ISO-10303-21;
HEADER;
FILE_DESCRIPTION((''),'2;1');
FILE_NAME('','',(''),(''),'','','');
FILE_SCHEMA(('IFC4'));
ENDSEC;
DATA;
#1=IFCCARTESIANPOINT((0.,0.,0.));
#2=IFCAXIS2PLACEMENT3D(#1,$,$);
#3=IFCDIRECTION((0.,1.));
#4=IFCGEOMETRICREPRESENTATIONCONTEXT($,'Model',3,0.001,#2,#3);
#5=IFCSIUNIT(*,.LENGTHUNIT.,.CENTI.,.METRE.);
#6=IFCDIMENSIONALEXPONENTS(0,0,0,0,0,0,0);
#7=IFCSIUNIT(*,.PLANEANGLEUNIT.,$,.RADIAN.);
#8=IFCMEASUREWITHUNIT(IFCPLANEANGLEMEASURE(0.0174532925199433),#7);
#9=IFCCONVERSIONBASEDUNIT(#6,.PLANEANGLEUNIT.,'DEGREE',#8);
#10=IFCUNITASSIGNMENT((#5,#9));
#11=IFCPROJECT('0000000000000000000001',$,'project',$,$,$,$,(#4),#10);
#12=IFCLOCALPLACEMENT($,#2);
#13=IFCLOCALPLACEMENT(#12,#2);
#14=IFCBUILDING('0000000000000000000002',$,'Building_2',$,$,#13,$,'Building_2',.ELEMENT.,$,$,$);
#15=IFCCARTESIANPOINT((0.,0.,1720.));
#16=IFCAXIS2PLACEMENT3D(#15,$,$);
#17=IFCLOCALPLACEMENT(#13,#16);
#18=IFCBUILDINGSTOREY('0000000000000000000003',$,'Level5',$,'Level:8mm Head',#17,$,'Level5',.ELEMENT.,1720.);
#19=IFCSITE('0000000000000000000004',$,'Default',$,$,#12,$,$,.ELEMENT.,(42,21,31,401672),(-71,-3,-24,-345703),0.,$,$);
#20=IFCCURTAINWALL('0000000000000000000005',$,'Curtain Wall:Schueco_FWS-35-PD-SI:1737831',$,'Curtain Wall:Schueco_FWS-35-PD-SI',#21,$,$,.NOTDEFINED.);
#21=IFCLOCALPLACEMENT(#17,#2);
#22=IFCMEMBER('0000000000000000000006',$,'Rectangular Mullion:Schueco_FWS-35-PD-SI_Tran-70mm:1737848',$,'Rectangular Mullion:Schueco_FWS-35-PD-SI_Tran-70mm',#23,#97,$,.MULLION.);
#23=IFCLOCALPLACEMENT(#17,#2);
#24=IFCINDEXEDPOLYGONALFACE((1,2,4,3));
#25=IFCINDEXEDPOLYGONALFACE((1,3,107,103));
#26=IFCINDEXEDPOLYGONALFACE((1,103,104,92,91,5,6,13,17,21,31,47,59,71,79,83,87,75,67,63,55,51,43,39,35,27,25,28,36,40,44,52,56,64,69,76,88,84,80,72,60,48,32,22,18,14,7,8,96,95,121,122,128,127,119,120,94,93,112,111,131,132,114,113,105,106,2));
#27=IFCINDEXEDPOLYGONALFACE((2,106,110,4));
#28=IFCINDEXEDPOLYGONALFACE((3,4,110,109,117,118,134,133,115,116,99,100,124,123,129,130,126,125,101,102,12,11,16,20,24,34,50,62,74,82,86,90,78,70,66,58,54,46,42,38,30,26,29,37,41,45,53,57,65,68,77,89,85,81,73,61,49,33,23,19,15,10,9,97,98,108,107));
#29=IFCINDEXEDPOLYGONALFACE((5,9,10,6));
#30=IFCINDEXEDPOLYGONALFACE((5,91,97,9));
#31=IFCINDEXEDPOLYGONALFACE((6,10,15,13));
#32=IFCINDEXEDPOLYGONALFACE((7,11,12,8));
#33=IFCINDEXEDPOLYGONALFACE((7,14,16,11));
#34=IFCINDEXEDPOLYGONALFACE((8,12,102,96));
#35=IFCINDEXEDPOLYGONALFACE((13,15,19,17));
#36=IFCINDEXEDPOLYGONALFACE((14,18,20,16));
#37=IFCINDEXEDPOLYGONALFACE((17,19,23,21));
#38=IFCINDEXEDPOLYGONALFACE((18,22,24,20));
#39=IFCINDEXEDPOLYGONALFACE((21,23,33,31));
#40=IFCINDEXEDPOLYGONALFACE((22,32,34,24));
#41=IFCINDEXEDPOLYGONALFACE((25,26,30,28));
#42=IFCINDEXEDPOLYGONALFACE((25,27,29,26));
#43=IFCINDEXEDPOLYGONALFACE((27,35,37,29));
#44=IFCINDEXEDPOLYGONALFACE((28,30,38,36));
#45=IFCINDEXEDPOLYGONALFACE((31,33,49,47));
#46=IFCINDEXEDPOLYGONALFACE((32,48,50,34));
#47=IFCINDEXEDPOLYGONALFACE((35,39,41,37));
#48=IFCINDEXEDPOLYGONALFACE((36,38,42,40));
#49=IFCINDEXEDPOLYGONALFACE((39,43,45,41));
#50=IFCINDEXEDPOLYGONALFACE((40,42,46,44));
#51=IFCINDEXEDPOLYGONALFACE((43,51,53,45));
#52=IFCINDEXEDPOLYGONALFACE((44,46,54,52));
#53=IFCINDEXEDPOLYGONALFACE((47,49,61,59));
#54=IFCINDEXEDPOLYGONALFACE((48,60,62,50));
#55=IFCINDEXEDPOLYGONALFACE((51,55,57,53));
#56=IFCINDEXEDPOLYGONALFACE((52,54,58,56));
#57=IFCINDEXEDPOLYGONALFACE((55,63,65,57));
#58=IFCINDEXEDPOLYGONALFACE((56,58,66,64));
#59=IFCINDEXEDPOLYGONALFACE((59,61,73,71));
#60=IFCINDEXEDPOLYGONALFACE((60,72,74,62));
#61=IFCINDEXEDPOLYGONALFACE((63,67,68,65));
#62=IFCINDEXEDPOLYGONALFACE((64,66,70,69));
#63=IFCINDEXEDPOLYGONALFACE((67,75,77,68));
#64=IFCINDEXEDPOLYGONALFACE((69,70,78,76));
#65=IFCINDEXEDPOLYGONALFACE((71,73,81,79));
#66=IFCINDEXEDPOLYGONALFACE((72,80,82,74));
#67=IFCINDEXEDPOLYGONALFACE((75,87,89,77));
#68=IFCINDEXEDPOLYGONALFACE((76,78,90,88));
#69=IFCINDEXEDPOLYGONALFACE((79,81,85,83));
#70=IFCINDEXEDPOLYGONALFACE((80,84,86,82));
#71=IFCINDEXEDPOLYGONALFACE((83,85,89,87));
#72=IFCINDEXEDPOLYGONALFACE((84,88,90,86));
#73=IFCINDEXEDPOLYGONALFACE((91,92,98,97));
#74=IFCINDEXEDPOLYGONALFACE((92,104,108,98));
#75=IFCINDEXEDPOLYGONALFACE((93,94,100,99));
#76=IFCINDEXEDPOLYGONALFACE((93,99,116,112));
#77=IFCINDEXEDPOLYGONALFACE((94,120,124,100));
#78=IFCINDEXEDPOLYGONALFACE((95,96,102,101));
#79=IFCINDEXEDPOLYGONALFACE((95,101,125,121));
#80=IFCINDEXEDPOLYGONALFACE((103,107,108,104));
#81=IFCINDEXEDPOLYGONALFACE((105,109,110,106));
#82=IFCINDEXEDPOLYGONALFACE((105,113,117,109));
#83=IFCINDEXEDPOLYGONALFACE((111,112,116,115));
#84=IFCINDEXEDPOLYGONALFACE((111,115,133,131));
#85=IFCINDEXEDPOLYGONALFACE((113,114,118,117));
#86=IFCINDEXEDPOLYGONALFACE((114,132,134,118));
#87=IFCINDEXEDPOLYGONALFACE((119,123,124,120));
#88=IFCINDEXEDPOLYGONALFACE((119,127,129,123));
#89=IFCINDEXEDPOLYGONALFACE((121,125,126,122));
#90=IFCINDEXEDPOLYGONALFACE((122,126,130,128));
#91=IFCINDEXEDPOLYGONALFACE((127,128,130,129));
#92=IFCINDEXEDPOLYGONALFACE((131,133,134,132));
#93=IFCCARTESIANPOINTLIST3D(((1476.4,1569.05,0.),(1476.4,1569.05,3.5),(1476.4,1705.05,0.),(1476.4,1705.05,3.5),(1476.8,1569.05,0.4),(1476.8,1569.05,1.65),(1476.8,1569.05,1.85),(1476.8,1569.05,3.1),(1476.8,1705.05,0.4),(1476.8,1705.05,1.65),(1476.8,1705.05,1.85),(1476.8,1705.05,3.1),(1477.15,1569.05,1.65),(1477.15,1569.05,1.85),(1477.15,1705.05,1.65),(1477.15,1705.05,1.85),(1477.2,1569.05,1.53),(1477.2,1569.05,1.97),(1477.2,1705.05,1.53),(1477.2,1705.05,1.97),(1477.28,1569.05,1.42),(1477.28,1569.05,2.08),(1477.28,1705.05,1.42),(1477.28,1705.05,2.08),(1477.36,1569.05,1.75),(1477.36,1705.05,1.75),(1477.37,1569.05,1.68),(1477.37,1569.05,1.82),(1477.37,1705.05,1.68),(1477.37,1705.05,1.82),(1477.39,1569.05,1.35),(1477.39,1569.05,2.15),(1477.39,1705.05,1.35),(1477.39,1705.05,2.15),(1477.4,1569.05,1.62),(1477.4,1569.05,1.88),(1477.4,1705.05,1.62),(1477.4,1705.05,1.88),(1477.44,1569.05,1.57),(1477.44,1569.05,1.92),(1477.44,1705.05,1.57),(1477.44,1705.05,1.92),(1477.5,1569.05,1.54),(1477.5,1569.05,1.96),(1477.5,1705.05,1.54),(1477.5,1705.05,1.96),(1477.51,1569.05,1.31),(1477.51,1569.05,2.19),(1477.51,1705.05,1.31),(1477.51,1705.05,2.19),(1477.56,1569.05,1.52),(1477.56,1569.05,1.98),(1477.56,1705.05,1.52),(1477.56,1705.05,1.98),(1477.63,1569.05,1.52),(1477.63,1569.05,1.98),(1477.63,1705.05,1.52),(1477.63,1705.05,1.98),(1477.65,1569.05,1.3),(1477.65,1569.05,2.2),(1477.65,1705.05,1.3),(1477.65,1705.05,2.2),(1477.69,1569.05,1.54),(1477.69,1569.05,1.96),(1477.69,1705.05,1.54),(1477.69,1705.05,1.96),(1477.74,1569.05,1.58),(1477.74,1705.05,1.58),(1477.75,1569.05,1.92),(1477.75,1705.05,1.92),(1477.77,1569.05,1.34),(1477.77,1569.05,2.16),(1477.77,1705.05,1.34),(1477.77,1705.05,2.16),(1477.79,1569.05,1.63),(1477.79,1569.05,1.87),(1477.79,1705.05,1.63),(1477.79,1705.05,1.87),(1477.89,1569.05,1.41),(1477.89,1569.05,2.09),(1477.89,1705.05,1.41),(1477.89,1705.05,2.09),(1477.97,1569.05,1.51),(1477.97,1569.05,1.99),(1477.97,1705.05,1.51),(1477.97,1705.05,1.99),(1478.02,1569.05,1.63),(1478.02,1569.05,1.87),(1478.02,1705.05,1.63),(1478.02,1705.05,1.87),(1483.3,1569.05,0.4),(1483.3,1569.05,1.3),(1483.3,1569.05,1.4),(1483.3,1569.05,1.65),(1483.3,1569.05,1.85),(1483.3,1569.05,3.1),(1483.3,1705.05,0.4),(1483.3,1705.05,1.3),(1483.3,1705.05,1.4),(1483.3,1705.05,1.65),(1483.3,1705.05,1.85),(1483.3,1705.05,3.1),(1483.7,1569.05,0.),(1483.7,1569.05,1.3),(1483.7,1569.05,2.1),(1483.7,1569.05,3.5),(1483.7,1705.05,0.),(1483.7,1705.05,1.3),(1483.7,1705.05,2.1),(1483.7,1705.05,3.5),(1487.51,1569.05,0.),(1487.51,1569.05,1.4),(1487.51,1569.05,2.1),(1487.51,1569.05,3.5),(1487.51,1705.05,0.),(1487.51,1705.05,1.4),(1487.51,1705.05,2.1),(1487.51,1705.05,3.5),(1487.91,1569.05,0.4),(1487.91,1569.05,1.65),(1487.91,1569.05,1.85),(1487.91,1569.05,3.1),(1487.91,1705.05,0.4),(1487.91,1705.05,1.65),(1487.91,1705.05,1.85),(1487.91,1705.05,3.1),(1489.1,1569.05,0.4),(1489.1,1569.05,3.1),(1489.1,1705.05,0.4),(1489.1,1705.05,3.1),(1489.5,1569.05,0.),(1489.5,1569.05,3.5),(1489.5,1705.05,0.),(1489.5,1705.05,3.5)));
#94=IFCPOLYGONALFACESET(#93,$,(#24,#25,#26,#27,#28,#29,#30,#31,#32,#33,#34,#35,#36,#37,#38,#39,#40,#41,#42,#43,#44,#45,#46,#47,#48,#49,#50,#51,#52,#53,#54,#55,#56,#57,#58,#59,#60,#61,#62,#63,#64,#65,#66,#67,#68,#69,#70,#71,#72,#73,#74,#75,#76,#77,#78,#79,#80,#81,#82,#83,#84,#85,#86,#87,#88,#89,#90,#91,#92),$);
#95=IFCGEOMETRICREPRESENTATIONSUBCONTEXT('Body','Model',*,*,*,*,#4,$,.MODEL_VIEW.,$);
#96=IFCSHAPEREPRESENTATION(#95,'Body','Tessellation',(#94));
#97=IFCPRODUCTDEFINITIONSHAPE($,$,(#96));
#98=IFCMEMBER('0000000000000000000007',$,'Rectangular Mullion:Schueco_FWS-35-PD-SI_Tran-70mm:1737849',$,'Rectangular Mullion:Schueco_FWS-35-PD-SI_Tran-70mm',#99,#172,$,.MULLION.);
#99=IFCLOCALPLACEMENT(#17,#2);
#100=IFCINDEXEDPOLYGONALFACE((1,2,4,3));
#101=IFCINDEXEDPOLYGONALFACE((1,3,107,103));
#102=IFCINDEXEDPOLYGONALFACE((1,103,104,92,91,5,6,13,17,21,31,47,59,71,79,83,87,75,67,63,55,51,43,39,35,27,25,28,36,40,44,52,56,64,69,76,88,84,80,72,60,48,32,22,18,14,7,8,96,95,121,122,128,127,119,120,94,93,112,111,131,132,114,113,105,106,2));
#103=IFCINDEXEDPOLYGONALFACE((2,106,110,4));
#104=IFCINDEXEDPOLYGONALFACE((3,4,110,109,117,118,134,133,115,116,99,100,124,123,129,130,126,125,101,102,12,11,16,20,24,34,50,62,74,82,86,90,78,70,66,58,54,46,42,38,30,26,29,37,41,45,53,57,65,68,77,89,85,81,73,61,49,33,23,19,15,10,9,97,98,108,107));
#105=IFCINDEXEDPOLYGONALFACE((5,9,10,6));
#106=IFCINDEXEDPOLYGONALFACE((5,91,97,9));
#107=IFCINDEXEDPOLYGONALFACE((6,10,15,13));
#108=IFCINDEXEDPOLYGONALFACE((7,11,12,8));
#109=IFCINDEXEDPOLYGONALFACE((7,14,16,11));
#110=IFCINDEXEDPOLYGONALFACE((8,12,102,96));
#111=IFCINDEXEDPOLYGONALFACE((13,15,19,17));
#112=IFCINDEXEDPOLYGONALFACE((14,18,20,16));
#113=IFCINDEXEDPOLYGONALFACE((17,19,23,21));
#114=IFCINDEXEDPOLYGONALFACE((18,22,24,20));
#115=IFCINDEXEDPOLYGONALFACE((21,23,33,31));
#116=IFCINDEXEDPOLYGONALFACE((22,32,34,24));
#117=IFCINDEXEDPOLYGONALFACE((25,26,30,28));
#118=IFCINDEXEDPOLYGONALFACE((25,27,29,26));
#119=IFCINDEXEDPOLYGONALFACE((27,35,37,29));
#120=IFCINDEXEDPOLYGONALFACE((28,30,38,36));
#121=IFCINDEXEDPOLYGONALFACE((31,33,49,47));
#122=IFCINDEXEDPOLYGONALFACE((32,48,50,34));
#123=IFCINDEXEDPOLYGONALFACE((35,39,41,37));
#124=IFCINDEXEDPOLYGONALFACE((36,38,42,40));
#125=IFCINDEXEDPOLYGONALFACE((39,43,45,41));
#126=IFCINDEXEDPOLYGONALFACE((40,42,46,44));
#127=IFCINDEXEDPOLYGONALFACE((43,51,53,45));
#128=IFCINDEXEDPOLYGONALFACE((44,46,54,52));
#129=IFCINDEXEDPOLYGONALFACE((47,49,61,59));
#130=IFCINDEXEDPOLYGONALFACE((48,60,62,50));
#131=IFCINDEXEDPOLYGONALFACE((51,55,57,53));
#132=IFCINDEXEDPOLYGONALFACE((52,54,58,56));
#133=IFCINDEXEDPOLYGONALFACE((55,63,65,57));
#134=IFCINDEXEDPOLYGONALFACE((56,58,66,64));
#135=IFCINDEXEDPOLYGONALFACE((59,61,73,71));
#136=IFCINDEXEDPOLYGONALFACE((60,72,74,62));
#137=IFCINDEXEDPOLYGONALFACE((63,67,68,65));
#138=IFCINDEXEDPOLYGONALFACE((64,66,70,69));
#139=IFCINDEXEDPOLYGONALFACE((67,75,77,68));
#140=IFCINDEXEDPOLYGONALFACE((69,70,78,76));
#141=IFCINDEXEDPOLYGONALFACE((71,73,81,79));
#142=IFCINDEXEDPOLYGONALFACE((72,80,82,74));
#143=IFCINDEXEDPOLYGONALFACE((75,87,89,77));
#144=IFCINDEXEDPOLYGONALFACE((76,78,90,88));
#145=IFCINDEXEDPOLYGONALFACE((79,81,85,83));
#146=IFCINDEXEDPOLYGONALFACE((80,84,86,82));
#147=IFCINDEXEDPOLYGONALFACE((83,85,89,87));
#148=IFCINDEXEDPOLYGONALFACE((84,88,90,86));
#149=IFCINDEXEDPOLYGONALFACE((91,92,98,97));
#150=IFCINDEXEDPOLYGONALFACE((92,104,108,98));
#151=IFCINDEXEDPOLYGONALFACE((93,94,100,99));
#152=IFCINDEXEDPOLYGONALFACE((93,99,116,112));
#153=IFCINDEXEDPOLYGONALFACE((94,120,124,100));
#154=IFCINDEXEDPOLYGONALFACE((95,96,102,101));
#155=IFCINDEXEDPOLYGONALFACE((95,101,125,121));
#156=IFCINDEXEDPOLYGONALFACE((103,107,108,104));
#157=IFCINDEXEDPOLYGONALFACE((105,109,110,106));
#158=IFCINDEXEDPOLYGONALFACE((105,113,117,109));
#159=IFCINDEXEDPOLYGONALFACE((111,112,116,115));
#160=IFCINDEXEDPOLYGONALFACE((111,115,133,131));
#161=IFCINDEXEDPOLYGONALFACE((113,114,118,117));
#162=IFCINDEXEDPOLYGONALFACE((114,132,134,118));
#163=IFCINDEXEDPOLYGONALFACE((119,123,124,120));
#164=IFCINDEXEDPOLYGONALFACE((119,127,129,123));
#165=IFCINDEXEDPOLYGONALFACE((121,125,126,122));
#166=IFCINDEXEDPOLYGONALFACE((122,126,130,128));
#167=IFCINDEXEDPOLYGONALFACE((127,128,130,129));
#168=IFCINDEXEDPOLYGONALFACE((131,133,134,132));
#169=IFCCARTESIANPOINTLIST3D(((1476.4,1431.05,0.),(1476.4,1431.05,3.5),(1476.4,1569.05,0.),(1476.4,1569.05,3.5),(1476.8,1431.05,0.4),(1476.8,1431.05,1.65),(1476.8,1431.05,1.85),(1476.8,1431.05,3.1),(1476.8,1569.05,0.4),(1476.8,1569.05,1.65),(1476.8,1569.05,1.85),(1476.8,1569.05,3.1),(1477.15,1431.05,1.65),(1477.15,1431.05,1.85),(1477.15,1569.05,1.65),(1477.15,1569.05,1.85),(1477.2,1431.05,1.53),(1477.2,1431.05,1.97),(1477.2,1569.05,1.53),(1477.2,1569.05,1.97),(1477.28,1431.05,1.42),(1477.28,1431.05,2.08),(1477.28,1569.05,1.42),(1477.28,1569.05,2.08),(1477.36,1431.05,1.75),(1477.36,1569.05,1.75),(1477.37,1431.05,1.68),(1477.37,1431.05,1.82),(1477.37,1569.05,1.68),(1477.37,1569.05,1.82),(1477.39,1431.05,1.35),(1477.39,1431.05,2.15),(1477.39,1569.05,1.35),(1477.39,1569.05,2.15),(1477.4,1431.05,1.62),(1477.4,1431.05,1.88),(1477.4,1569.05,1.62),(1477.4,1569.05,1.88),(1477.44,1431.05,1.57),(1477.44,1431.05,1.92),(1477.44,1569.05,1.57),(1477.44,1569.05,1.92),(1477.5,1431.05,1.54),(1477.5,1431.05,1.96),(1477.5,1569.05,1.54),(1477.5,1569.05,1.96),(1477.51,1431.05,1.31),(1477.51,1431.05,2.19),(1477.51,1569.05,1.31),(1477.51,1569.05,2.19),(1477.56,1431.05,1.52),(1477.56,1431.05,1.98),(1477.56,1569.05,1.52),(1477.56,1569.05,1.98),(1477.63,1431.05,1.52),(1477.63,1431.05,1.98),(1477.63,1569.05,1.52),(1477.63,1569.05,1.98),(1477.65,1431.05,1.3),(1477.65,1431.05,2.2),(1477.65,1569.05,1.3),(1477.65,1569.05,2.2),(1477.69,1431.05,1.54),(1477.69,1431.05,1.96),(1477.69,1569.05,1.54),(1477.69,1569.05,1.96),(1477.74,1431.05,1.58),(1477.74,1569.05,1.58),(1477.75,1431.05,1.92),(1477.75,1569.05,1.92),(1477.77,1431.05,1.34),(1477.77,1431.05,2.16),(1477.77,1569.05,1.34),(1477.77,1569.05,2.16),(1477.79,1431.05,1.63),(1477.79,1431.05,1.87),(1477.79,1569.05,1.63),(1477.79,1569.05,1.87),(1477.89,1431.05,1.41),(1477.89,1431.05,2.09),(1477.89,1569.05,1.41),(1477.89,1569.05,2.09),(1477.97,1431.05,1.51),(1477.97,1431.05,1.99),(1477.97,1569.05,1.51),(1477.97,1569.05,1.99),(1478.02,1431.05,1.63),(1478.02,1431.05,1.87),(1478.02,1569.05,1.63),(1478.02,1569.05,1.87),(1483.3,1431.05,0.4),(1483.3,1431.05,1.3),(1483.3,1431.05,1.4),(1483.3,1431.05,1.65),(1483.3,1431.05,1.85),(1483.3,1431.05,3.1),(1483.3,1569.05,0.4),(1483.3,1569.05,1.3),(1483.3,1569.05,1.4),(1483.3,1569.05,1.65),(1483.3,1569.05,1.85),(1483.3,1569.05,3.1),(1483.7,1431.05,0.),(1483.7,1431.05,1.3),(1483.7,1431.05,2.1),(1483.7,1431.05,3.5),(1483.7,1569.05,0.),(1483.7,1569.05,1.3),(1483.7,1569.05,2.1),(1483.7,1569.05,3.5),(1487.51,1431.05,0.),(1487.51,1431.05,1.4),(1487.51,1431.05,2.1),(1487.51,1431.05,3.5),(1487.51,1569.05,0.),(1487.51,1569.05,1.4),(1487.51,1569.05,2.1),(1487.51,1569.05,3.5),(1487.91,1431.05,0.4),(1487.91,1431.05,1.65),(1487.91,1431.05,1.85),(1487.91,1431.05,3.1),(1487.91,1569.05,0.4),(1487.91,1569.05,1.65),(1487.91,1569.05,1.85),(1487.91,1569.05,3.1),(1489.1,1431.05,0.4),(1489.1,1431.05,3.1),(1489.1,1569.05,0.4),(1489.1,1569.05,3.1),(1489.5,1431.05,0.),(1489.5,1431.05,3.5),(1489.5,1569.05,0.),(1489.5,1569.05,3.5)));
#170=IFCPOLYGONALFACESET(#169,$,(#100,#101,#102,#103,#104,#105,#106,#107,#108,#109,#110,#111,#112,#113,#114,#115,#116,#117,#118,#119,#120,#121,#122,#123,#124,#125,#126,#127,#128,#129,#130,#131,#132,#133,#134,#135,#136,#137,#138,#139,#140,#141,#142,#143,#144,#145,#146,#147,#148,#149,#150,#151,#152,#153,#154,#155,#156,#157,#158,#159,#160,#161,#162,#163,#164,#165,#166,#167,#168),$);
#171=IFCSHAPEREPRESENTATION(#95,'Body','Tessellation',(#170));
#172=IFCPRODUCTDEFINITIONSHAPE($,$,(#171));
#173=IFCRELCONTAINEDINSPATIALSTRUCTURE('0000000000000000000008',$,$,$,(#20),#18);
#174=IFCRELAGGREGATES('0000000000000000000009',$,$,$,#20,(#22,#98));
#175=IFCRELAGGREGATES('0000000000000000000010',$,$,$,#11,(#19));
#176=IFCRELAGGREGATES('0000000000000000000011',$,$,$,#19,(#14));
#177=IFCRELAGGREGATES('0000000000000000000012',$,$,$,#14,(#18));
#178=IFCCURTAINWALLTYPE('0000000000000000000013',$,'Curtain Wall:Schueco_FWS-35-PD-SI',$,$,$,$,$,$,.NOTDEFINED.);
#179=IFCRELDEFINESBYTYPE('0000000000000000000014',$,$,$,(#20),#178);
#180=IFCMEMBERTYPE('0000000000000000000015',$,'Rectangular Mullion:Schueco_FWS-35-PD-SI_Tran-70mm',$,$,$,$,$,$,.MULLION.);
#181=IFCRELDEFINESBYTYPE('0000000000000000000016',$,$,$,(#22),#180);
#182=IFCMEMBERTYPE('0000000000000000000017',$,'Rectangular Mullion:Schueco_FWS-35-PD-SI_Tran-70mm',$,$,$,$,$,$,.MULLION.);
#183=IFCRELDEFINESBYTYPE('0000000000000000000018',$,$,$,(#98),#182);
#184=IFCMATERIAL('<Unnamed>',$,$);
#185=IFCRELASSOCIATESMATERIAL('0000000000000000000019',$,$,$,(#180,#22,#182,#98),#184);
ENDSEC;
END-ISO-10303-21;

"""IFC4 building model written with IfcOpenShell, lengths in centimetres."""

from ifc_helpers import new_model, entity, si_unit, converted_unit, direction, frame, origin, place, context, subcontext, project, spatial, line, arc, indexed_curve, outline, extrude, source, transform, mapped, material, type_object, type_shapes, element, aggregate, save


model = new_model("IFC4")

# Units and contexts
model_context = context("Model", 3, precision=0.001, world=origin(), true_north=direction((0.0, 1.0)))
body_context = subcontext(model_context, "Body", "Model", "MODEL_VIEW")
ifc_project = project(units=[si_unit("LENGTHUNIT", "METRE", prefix="CENTI"), converted_unit("PLANEANGLEUNIT", "DEGREE", entity("IfcPlaneAngleMeasure", 0.0174532925199433), si_unit("PLANEANGLEUNIT", "RADIAN"), dimensions=[0, 0, 0, 0, 0, 0, 0])], contexts=[model_context])

# Site, building, storey
site_placement = place(None, origin())
site = spatial("IfcSite", under=ifc_project, at=site_placement, Name="Default", CompositionType="ELEMENT", RefLatitude=(42, 21, 31, 401672), RefLongitude=(-71, -3, -24, -345703), RefElevation=0.0)
building_placement = place(site_placement, origin())
building = spatial("IfcBuilding", under=site, at=building_placement, Name="Building_2", LongName="Building_2", CompositionType="ELEMENT")
storey_placement = place(building_placement, frame((0.0, 0.0, 1720.0)))
storey = spatial("IfcBuildingStorey", under=building, at=storey_placement, Name="Level5", ObjectType="Level:8mm Head", LongName="Level5", CompositionType="ELEMENT", Elevation=1720.0)

# Curtain wall, members
curtain_wall_type = type_object("IfcCurtainWallType", Name="Curtain Wall:Schueco_FWS-35-PD-SI", PredefinedType="NOTDEFINED")
curtain_wall_placement = place(storey_placement, frame((0.0, 0.0, -1720.0)))
curtain_wall = element("IfcCurtainWall", 1, at=curtain_wall_placement, inside=storey, type_object=curtain_wall_type, Name="Curtain Wall:Schueco_FWS-35-PD-SI:1737831", ObjectType="Curtain Wall:Schueco_FWS-35-PD-SI", PredefinedType="NOTDEFINED")
ifc_material_1 = material(Name="<Unnamed>")
member_type_1 = type_object("IfcMemberType", Name="Rectangular Mullion:Schueco_FWS-35-PD-SI_Tran-70mm", PredefinedType="MULLION", material=ifc_material_1)
shared_shape_1 = source(origin(), body_context, "Body", "SweptSolid", [
    extrude(outline(indexed_curve([(-6.52, -1.78), (0.78, -1.78), (0.78, -0.38), (4.59, -0.38), (4.59, -1.78), (6.58, -1.78), (6.58, 1.72), (4.59, 1.72), (4.59, 0.32), (0.38, 0.32), (0.38, 0.07), (4.99, 0.07), (4.99, 1.32), (6.18, 1.32), (6.18, -1.38), (4.99, -1.38), (4.99, -0.13), (0.38, -0.13), (0.38, -1.38), (-6.12, -1.38), (-6.12, -0.13), (-5.77, -0.13), (-5.34, -0.48), (-4.9, -0.15), (-5.14, -0.15), (-5.56, -0.03), (-5.14, 0.09), (-4.9, 0.09), (-5.34, 0.42), (-5.77, 0.07), (-6.12, 0.07), (-6.12, 1.32), (0.38, 1.32), (0.38, 0.42), (0.78, 0.42), (0.78, 1.72), (-6.52, 1.72)], segments=[line(1, 2, 3, 4, 5, 6, 7, 8, 9, 10, 11, 12, 13, 14, 15, 16, 17, 18, 19, 20, 21, 22), arc(22, 23, 24), line(24, 25), arc(25, 26, 27), line(27, 28), arc(28, 29, 30), line(30, 31, 32, 33, 34, 35, 36, 37, 1)], self_intersect=False)), frame((-1.72, 4.58, -136.0), z_axis=(0.0, 0.0, 1.0), x_axis=(0.0, -1.0, 0.0)), (0.0, 0.0, 1.0), 136.0),
])
type_shapes(member_type_1, [shared_shape_1])
member_1_placement = place(curtain_wall_placement, frame((1487.5, 1705.05, 1720.0), z_axis=(0.0, 1.0, 0.0), x_axis=(0.0, 0.0, -1.0)))
member_1 = element("IfcMember", 2, at=member_1_placement, type_object=member_type_1, material=ifc_material_1, Name="Rectangular Mullion:Schueco_FWS-35-PD-SI_Tran-70mm:1737848", ObjectType="Rectangular Mullion:Schueco_FWS-35-PD-SI_Tran-70mm", PredefinedType="MULLION", context=body_context, shape_type="MappedRepresentation", body=[
    mapped(shared_shape_1, transform((0.0, 0.0, 0.0), scale=1.0)),
])
member_type_2 = type_object("IfcMemberType", Name="Rectangular Mullion:Schueco_FWS-35-PD-SI_Tran-70mm", PredefinedType="MULLION", material=ifc_material_1)
shared_shape_2 = source(origin(), body_context, "Body", "SweptSolid", [
    extrude(outline(indexed_curve([(-6.52, -1.78), (0.78, -1.78), (0.78, -0.38), (4.59, -0.38), (4.59, -1.78), (6.58, -1.78), (6.58, 1.72), (4.59, 1.72), (4.59, 0.32), (0.38, 0.32), (0.38, 0.07), (4.99, 0.07), (4.99, 1.32), (6.18, 1.32), (6.18, -1.38), (4.99, -1.38), (4.99, -0.13), (0.38, -0.13), (0.38, -1.38), (-6.12, -1.38), (-6.12, -0.13), (-5.77, -0.13), (-5.34, -0.48), (-4.9, -0.15), (-5.14, -0.15), (-5.56, -0.03), (-5.14, 0.09), (-4.9, 0.09), (-5.34, 0.42), (-5.77, 0.07), (-6.12, 0.07), (-6.12, 1.32), (0.38, 1.32), (0.38, 0.42), (0.78, 0.42), (0.78, 1.72), (-6.52, 1.72)], segments=[line(1, 2, 3, 4, 5, 6, 7, 8, 9, 10, 11, 12, 13, 14, 15, 16, 17, 18, 19, 20, 21, 22), arc(22, 23, 24), line(24, 25), arc(25, 26, 27), line(27, 28), arc(28, 29, 30), line(30, 31, 32, 33, 34, 35, 36, 37, 1)], self_intersect=False)), frame((-1.72, 4.58, -138.0), z_axis=(0.0, 0.0, 1.0), x_axis=(0.0, -1.0, 0.0)), (0.0, 0.0, 1.0), 138.0),
])
type_shapes(member_type_2, [shared_shape_2])
member_2_placement = place(curtain_wall_placement, frame((1487.5, 1569.05, 1720.0), z_axis=(0.0, 1.0, 0.0), x_axis=(0.0, 0.0, -1.0)))
member_2 = element("IfcMember", 3, at=member_2_placement, type_object=member_type_2, material=ifc_material_1, Name="Rectangular Mullion:Schueco_FWS-35-PD-SI_Tran-70mm:1737849", ObjectType="Rectangular Mullion:Schueco_FWS-35-PD-SI_Tran-70mm", PredefinedType="MULLION", context=body_context, shape_type="MappedRepresentation", body=[
    mapped(shared_shape_2, transform((0.0, 0.0, 0.0), scale=1.0)),
])

aggregate(curtain_wall, [member_1, member_2])

save(model, "model.ifc")
